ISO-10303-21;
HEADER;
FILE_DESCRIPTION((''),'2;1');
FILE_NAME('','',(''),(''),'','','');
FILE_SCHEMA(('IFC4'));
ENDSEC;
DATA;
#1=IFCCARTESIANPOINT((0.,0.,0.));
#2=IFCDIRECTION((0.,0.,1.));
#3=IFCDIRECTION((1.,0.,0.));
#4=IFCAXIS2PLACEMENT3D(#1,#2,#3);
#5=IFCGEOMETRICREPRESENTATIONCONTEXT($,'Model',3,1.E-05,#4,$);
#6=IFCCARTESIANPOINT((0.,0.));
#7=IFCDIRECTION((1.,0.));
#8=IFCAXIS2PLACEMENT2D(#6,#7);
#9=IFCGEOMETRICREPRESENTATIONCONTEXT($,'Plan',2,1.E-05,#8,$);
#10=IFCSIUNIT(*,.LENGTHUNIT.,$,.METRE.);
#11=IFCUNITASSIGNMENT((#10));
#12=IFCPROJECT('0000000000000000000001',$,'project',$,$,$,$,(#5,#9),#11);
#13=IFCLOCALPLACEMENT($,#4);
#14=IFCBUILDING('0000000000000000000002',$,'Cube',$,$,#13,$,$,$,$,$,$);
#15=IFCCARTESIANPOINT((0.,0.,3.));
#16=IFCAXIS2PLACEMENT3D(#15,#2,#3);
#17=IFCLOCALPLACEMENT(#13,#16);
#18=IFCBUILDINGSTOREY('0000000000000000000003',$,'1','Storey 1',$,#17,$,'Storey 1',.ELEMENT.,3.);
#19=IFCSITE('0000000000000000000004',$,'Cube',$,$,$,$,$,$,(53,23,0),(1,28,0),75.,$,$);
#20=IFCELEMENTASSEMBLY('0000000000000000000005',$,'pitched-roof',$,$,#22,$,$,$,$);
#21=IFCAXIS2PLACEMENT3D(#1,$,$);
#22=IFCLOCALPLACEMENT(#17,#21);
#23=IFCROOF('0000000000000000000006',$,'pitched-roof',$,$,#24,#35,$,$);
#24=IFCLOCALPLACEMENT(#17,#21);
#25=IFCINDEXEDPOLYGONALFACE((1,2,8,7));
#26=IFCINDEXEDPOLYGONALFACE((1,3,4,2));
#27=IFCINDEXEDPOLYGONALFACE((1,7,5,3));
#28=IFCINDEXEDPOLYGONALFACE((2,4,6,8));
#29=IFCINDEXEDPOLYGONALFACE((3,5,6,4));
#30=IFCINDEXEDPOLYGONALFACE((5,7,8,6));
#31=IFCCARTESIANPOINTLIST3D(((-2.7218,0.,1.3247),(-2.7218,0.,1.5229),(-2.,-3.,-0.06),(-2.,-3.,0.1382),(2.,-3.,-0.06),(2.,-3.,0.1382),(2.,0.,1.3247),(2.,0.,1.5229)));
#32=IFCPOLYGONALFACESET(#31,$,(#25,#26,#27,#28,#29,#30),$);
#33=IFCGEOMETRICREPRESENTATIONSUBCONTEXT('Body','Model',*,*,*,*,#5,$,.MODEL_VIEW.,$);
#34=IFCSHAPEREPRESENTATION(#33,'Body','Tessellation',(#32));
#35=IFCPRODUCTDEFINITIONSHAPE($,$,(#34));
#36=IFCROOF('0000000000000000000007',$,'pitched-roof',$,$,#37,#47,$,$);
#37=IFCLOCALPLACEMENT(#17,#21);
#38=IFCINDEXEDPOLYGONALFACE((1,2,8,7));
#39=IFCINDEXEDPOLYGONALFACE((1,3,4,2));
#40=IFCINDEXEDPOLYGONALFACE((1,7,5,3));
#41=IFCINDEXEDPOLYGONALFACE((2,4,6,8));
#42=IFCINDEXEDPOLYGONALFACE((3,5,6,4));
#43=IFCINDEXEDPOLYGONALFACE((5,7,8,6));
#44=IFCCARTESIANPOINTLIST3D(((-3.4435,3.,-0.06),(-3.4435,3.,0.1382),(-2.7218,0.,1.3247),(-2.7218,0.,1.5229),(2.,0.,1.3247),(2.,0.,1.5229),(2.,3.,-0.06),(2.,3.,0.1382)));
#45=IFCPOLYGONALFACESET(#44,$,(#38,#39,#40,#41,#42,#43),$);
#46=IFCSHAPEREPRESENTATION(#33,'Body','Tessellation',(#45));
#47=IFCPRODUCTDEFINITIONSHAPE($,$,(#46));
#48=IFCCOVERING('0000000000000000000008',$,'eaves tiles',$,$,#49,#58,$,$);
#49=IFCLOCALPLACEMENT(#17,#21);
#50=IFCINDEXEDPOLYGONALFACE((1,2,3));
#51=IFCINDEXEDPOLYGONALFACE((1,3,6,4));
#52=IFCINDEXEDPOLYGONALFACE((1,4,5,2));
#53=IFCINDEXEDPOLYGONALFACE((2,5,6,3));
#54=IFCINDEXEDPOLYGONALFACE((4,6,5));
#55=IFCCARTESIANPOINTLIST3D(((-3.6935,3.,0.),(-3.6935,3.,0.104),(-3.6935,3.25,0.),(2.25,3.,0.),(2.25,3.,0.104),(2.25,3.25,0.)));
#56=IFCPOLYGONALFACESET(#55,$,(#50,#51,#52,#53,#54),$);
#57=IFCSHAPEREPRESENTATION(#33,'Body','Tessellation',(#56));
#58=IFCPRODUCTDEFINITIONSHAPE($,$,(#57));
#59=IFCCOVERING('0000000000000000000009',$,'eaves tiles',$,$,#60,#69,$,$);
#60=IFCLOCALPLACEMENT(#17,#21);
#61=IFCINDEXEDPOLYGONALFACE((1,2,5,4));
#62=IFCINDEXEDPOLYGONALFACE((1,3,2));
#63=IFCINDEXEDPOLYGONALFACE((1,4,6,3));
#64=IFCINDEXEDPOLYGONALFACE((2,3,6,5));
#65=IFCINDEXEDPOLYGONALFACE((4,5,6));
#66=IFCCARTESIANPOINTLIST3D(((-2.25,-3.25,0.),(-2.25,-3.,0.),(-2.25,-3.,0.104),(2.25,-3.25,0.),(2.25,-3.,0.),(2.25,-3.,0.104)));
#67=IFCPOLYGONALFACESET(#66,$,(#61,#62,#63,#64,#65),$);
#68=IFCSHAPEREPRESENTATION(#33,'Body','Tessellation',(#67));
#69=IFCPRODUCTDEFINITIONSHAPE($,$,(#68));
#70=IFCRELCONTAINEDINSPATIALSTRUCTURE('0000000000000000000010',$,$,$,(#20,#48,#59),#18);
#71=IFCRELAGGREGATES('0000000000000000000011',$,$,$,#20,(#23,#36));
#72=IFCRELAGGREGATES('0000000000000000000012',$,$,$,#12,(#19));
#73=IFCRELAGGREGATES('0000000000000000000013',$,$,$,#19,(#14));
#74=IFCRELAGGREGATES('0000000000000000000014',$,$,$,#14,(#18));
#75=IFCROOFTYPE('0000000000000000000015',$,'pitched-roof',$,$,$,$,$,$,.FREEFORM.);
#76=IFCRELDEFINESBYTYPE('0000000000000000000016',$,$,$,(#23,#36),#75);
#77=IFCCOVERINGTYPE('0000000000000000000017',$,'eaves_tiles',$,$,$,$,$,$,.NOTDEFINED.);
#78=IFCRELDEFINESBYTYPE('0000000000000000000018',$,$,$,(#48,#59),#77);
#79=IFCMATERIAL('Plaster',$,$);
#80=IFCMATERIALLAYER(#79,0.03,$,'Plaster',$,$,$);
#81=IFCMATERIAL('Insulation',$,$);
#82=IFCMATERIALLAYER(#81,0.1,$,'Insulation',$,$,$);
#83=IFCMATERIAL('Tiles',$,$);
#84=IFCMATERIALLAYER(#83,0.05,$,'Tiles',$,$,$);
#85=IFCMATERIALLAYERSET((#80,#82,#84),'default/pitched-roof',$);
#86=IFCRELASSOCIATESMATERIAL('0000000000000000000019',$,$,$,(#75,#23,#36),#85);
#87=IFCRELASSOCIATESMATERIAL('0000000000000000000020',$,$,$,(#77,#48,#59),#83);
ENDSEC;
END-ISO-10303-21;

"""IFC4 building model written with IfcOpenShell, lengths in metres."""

from ifc_helpers import new_model, si_unit, frame, origin, origin_with_axes, origin_2d_with_axis, place, context, subcontext, project, spatial, polyline, outline, extrude, material, layer, layer_set, layer_usage, material_profile, profile_set, profile_usage, type_object, element, aggregate, save


model = new_model("IFC4")

# Units and contexts
model_context = context("Model", 3, precision=1e-05, world=origin_with_axes())
plan_context = context("Plan", 2, precision=1e-05, world=origin_2d_with_axis())
body_context = subcontext(model_context, "Body", "Model", "MODEL_VIEW")
ifc_project = project(units=[si_unit("LENGTHUNIT", "METRE")], contexts=[model_context, plan_context])

# Site, building, storey
site = spatial("IfcSite", under=ifc_project, Name="Cube", RefLatitude=(53, 23, 0), RefLongitude=(1, 28, 0), RefElevation=75.0)
building_placement = place(None, origin_with_axes())
building = spatial("IfcBuilding", under=site, at=building_placement, Name="Cube")
storey_placement = place(building_placement, frame((0.0, 0.0, 3.0), z_axis=(0.0, 0.0, 1.0), x_axis=(1.0, 0.0, 0.0)))
storey = spatial("IfcBuildingStorey", under=building, at=storey_placement, Name="1", Description="Storey 1", LongName="Storey 1", CompositionType="ELEMENT", Elevation=3.0)

# Element assembly, roofs
assembly_placement = place(storey_placement, frame((0.0, 0.0, -3.0), z_axis=(0.0, 0.0, 1.0), x_axis=(1.0, 0.0, 0.0)))
assembly = element("IfcElementAssembly", 1, at=assembly_placement, inside=storey, Name="pitched-roof")
ifc_material_1 = material(Name="Plaster")
ifc_layer_1 = layer(ifc_material_1, 0.03, Name="Plaster")
ifc_material_2 = material(Name="Insulation")
ifc_layer_2 = layer(ifc_material_2, 0.1, Name="Insulation")
ifc_material_3 = material(Name="Tiles")
ifc_layer_3 = layer(ifc_material_3, 0.05, Name="Tiles")
ifc_layer_set = layer_set([ifc_layer_1, ifc_layer_2, ifc_layer_3], Name="default/pitched-roof")
ifc_layer_usage_1 = layer_usage(ifc_layer_set, "AXIS3", "POSITIVE", 0.0)
roof_type = type_object("IfcRoofType", Name="pitched-roof", PredefinedType="FREEFORM", material=ifc_layer_set)
roof_1_placement = place(assembly_placement, frame((-2.0, -3.0, 2.94), z_axis=(0.0, -0.419069, 0.907954), x_axis=(1.0, 0.0, 0.0)))
roof_1 = element("IfcRoof", 2, at=roof_1_placement, type_object=roof_type, material=ifc_layer_usage_1, Name="pitched-roof", context=body_context, shape_type="SweptSolid", body=[
    extrude(outline(polyline([(0.0, 0.0), (4.0, 0.0), (4.0, 3.3041), (-0.7218, 3.3041), (0.0, 0.0)])), origin(), (0.0, 0.419069, 0.907954), 0.1982),
])
ifc_layer_usage_2 = layer_usage(ifc_layer_set, "AXIS3", "POSITIVE", 0.0)
roof_2_placement = place(assembly_placement, frame((-3.4435, 3.0, 2.94), z_axis=(0.0, 0.419069, 0.907954), x_axis=(-1.0, 0.0, 0.0)))
roof_2 = element("IfcRoof", 3, at=roof_2_placement, type_object=roof_type, material=ifc_layer_usage_2, Name="pitched-roof", context=body_context, shape_type="SweptSolid", body=[
    extrude(outline(polyline([(0.0, 0.0), (-0.7218, 3.3041), (-5.4435, 3.3041), (-5.4435, 0.0), (0.0, 0.0)])), origin(), (0.0, 0.419069, 0.907954), 0.1982),
])
aggregate(assembly, [roof_1, roof_2])

# Coverings
ifc_material_profile_1 = material_profile(ifc_material_3, outline(polyline([(0.25, 0.0), (0.0, 0.0), (0.0, 0.104), (0.25, 0.0)])))
ifc_profile_set_1 = profile_set([ifc_material_profile_1])
ifc_profile_usage_1 = profile_usage(ifc_profile_set_1)
covering_type_1 = type_object("IfcCoveringType", Name="eaves_tiles", PredefinedType="NOTDEFINED", material=ifc_profile_set_1)
covering_1_placement = place(storey_placement, frame((-3.6935, 3.0, 0.0), z_axis=(1.0, 0.0, 0.0), x_axis=(0.0, 1.0, 0.0)))
element("IfcCovering", 4, at=covering_1_placement, inside=storey, type_object=covering_type_1, material=ifc_profile_usage_1, Name="eaves tiles", context=body_context, shape_type="SweptSolid", body=[
    extrude(outline(polyline([(0.25, 0.0), (0.0, 0.0), (0.0, 0.104), (0.25, 0.0)])), origin_with_axes(), (0.0, 0.0, 1.0), 5.9435),
])
ifc_profile_usage_2 = profile_usage(ifc_profile_set_1)
covering_2_placement = place(storey_placement, frame((2.25, -3.0, 0.0), z_axis=(-1.0, 0.0, 0.0), x_axis=(0.0, -1.0, 0.0)))
element("IfcCovering", 5, at=covering_2_placement, inside=storey, type_object=covering_type_1, material=ifc_profile_usage_2, Name="eaves tiles", context=body_context, shape_type="SweptSolid", body=[
    extrude(outline(polyline([(0.25, 0.0), (0.0, 0.0), (0.0, 0.104), (0.25, 0.0)])), origin_with_axes(), (0.0, 0.0, 1.0), 4.5),
])

save(model, "model.ifc")
